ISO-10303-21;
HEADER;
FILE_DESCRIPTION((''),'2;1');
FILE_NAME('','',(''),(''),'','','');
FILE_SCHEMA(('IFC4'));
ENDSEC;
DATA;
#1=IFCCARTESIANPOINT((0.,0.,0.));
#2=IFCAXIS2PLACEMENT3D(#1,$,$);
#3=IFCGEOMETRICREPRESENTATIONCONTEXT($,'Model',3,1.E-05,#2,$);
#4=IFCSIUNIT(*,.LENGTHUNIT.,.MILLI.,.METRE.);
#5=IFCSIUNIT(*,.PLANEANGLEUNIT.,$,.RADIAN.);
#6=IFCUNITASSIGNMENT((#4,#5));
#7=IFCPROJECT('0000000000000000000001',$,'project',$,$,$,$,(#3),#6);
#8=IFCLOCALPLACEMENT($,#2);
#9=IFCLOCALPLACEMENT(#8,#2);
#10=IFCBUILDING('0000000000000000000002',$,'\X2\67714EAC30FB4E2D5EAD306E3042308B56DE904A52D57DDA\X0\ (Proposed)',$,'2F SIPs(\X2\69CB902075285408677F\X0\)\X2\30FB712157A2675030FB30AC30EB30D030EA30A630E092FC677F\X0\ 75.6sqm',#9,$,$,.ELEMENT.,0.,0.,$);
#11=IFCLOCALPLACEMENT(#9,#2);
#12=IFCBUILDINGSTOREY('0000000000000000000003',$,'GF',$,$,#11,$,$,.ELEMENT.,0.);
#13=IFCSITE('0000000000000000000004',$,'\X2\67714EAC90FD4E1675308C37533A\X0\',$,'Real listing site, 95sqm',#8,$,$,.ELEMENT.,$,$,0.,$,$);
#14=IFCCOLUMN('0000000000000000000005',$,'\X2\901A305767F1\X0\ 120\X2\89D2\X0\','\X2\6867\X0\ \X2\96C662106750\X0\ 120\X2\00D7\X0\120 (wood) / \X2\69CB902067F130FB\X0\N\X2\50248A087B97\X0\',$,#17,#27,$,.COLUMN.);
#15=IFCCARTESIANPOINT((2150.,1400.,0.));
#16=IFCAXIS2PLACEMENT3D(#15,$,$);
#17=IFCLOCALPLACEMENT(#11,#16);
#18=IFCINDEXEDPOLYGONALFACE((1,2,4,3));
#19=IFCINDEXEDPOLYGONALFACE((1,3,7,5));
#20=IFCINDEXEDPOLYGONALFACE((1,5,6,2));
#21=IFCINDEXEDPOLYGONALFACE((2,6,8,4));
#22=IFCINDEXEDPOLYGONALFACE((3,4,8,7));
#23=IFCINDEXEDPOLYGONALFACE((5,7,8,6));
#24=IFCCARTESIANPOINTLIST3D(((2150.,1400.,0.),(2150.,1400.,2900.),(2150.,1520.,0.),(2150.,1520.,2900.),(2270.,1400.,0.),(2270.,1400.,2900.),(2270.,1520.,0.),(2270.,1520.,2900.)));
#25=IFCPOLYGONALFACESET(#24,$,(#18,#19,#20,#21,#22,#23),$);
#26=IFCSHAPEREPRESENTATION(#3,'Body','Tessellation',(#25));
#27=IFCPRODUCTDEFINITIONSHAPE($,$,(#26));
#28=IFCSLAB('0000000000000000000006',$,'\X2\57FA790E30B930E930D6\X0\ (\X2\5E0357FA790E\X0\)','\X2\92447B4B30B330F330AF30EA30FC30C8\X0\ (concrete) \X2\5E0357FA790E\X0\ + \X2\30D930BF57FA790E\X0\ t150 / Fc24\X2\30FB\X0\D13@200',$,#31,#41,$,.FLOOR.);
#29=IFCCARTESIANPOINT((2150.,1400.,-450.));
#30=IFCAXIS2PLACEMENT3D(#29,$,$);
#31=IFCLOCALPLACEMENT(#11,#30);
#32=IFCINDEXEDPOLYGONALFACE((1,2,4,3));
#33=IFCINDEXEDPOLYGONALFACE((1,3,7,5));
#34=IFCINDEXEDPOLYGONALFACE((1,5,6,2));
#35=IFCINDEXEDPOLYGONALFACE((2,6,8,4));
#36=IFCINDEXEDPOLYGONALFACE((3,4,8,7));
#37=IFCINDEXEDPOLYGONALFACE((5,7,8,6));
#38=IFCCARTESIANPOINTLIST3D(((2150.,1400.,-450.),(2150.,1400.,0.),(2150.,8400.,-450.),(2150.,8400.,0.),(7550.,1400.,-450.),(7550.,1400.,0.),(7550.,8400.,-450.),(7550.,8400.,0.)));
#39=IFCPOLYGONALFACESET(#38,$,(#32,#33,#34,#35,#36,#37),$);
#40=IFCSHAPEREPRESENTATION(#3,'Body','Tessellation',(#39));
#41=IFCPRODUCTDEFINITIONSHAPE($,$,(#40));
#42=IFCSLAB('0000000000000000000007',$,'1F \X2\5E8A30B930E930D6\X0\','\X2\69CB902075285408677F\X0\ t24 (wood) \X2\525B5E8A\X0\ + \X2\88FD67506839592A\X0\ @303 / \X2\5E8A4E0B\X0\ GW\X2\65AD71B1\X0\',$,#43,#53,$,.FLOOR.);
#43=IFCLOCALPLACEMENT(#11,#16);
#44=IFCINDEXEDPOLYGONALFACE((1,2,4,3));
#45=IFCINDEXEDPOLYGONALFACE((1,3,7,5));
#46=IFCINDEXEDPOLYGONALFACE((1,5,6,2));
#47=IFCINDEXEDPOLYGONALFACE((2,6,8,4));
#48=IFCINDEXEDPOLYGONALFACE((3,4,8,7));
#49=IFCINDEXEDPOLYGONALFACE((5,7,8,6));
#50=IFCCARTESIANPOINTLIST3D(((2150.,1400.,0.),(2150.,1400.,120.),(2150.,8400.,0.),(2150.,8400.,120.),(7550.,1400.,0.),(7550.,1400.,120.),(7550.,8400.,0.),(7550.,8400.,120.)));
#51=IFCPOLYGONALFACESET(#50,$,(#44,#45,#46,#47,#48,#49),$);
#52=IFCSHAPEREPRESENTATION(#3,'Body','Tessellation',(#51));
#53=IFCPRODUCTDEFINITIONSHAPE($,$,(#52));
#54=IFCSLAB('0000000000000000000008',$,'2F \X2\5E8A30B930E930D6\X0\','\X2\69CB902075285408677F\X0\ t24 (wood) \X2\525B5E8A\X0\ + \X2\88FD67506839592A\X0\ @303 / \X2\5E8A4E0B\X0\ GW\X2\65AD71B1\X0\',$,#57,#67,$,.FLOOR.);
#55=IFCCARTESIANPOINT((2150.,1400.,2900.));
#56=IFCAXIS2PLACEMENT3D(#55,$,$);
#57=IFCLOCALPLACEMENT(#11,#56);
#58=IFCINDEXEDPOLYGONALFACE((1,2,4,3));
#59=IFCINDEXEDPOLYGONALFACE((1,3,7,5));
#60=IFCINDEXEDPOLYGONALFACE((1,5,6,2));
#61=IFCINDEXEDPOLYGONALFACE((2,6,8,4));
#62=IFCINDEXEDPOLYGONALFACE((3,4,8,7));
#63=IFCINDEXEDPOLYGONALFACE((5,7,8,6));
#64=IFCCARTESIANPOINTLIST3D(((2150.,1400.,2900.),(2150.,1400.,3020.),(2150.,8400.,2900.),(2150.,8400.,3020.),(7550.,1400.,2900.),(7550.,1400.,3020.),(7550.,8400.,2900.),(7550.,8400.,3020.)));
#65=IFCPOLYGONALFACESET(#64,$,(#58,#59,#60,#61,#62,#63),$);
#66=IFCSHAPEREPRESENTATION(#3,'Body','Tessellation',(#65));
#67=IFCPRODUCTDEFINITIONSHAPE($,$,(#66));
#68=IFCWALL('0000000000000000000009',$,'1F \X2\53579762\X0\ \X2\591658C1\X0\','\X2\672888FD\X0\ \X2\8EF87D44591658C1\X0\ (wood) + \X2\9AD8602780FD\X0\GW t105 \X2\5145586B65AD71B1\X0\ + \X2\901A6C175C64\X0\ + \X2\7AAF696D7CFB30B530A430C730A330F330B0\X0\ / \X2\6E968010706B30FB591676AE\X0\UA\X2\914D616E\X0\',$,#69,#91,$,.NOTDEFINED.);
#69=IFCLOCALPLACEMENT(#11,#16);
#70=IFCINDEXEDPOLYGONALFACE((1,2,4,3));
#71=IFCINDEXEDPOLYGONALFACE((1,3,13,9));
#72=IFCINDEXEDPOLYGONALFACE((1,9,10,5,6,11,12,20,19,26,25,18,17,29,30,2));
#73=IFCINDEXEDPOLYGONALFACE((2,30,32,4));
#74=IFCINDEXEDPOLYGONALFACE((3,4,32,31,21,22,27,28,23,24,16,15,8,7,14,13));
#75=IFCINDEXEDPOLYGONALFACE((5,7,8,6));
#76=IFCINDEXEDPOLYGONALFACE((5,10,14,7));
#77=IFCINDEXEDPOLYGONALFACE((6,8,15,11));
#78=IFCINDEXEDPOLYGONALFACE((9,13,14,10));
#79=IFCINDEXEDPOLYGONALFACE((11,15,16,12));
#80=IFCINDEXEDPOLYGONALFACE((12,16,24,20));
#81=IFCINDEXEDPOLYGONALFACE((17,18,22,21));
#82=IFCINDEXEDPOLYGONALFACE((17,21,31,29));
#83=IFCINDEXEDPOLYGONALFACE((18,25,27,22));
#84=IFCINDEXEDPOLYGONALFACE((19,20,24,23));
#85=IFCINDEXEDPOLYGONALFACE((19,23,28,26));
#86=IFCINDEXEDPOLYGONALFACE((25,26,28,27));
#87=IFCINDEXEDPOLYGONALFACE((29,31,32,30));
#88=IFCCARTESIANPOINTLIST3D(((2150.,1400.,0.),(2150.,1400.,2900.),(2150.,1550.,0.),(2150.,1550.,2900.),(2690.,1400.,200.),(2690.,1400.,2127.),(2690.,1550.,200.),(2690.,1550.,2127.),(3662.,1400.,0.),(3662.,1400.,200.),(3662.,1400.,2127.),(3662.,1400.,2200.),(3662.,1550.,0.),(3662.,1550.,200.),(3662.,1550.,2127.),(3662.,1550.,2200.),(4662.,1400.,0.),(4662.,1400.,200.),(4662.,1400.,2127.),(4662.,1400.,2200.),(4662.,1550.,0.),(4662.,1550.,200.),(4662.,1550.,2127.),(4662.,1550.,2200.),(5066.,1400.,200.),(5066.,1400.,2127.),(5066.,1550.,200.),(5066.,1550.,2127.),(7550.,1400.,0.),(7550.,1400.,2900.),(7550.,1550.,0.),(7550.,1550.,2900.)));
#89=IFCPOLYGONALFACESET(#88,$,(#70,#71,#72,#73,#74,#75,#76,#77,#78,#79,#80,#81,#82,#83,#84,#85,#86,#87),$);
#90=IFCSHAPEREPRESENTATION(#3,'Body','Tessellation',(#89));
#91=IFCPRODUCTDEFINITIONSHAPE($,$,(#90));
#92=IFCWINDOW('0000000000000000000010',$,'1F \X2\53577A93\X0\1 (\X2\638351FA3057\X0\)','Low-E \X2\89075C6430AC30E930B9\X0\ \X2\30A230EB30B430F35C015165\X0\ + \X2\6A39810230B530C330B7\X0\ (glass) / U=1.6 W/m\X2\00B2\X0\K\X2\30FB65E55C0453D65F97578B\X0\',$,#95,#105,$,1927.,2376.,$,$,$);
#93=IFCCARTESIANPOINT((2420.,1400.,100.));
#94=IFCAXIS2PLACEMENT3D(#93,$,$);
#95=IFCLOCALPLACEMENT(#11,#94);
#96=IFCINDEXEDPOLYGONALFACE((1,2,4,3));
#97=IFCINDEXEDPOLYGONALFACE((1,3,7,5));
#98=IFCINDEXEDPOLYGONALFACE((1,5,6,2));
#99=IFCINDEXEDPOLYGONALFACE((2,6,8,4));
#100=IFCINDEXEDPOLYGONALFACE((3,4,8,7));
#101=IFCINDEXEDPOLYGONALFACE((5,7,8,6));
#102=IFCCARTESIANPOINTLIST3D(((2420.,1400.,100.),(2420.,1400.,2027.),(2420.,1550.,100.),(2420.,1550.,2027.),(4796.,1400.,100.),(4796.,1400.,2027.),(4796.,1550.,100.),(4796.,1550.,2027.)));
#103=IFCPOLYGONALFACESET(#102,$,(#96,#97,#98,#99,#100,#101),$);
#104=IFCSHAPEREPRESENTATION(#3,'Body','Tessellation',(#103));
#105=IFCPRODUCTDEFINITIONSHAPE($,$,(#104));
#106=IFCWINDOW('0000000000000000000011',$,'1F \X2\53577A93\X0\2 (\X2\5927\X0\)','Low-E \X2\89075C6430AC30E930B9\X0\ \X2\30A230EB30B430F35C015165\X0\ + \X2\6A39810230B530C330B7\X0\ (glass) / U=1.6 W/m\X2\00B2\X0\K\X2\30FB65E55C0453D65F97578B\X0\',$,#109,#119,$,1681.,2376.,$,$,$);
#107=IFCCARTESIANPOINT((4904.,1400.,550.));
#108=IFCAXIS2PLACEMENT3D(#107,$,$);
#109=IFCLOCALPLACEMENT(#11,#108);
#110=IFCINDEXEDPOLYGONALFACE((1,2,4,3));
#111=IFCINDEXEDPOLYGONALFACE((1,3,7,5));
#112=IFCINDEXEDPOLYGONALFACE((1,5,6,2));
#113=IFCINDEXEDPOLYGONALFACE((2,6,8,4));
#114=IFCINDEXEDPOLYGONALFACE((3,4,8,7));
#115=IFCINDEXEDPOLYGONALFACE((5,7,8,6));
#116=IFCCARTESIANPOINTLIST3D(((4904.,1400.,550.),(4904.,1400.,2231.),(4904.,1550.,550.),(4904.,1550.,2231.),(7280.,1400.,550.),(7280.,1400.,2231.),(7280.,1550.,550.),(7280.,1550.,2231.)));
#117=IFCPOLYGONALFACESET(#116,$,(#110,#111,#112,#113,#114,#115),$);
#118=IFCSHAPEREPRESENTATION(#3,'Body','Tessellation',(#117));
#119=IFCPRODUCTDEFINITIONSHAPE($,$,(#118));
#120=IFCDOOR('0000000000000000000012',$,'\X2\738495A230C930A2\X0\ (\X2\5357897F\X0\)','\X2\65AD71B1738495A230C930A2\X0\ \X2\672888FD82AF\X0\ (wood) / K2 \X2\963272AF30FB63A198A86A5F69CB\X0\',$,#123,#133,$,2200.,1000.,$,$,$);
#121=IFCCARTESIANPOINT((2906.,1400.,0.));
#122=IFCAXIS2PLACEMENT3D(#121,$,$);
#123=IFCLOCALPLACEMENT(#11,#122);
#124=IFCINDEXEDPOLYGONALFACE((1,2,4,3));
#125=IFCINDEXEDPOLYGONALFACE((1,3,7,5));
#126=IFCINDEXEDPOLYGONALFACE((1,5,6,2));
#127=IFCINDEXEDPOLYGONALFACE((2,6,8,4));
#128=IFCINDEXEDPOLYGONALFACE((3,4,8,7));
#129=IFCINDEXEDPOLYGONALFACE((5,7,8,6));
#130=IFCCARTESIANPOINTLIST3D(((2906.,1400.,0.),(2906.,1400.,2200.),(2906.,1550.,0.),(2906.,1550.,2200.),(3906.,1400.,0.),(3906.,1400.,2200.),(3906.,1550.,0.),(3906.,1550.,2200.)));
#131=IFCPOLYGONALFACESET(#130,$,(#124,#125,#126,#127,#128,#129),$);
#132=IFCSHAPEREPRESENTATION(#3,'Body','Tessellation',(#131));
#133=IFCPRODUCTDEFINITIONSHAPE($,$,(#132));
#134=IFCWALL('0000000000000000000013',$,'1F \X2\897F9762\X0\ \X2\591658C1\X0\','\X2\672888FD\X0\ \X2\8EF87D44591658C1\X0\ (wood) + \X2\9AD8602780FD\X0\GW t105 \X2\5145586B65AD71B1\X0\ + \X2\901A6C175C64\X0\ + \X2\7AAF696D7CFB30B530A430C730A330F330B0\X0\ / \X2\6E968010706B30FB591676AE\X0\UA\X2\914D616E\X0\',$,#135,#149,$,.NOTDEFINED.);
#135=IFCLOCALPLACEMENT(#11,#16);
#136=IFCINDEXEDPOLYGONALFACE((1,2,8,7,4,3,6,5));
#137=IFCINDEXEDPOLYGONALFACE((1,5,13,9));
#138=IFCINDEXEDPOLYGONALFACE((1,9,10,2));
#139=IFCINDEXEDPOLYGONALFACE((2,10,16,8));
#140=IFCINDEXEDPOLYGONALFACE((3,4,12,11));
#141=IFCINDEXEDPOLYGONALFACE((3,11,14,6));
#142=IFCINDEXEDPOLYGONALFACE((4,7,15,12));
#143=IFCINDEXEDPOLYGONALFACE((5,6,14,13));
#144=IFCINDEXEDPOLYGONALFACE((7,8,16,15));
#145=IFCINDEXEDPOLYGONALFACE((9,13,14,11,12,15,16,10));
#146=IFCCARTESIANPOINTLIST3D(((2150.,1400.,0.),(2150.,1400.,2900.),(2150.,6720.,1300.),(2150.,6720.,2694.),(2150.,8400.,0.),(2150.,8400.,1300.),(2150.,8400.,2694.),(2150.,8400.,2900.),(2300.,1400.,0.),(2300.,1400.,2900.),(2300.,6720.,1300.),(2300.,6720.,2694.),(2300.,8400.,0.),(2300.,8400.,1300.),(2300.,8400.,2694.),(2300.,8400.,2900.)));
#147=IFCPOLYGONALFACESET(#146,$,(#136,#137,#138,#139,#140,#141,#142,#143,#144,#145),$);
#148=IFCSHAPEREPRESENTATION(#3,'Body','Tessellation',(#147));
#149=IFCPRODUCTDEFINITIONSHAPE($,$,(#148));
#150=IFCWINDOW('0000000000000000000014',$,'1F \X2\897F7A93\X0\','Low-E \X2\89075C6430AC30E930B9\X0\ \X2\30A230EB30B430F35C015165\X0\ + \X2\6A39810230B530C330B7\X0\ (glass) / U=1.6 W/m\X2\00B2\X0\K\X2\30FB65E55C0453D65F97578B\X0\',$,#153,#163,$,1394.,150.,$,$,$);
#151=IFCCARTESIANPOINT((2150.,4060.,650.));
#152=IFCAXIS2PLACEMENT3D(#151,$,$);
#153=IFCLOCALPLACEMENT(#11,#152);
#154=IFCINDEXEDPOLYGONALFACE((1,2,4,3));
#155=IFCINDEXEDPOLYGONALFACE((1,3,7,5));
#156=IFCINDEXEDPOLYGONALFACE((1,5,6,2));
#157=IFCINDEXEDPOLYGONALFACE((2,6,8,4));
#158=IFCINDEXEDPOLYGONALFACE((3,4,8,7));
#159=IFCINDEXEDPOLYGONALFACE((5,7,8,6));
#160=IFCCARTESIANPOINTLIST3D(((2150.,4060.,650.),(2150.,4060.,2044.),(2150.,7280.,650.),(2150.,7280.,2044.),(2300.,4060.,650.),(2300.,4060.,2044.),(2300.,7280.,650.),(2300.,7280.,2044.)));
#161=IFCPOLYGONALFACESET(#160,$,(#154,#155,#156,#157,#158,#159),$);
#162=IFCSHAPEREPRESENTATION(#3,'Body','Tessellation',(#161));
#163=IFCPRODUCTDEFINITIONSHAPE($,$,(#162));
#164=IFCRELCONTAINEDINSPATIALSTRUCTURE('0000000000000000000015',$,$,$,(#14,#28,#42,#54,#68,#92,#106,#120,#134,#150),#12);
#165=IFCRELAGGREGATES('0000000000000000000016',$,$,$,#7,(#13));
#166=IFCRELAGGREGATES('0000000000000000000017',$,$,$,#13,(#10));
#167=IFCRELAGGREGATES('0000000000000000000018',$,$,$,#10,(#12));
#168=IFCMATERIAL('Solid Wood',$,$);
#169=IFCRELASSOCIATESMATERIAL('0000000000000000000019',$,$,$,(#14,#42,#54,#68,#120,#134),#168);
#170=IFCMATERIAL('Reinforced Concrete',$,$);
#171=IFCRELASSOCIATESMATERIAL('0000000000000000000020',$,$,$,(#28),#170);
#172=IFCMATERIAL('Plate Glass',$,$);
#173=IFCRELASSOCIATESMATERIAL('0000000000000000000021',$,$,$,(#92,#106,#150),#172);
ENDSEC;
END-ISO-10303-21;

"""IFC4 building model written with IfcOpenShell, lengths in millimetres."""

from ifc_helpers import new_model, si_unit, frame, frame_2d, origin, place, context, project, spatial, rectangle, extrude, material, element, fill, save


model = new_model("IFC4")

# Units and contexts
model_context = context("Model", 3, precision=1e-05, world=origin())
ifc_project = project(units=[si_unit("LENGTHUNIT", "METRE", prefix="MILLI"), si_unit("PLANEANGLEUNIT", "RADIAN")], contexts=[model_context])

# Site, building, storey
site_placement = place(None, origin())
site = spatial("IfcSite", under=ifc_project, at=site_placement, Name="東京都世田谷区", ObjectType="Real listing site, 95sqm", CompositionType="ELEMENT", RefElevation=0.0)
building_placement = place(site_placement, origin())
building = spatial("IfcBuilding", under=site, at=building_placement, Name="東京・中庭のある回遊動線 (Proposed)", ObjectType="2F SIPs(構造用合板)・無垢材・ガルバリウム鋼板 75.6sqm", CompositionType="ELEMENT", ElevationOfRefHeight=0.0, ElevationOfTerrain=0.0)
storey_placement = place(building_placement, origin())
storey = spatial("IfcBuildingStorey", under=building, at=storey_placement, Name="GF", CompositionType="ELEMENT", Elevation=0.0)

# Column
ifc_material_1 = material(Name="Solid Wood")
column_placement = place(storey_placement, frame((2150.0, 1400.0, 0.0)))
element("IfcColumn", 1, at=column_placement, inside=storey, material=ifc_material_1, Name="通し柱 120角", Description="桧 集成材 120×120 (wood) / 構造柱・N値計算", PredefinedType="COLUMN", context=model_context, shape_type="SweptSolid", body=[
    extrude(rectangle(XDim=120.0, YDim=120.0, at=frame_2d((60.0, 60.0))), frame((2150.0, 1400.0, 0.0)), (0.0, 0.0, 1.0), 2900.0),
])

# Slabs
ifc_material_2 = material(Name="Reinforced Concrete")
slab_1_placement = place(storey_placement, frame((2150.0, 1400.0, -450.0)))
element("IfcSlab", 2, at=slab_1_placement, inside=storey, material=ifc_material_2, Name="基礎スラブ (布基礎)", Description="鉄筋コンクリート (concrete) 布基礎 + ベタ基礎 t150 / Fc24・D13@200", PredefinedType="FLOOR", context=model_context, shape_type="SweptSolid", body=[
    extrude(rectangle(XDim=5400.0, YDim=7000.0, at=frame_2d((2700.0, 3500.0))), frame((2150.0, 1400.0, -450.0)), (0.0, 0.0, 1.0), 450.0),
])
slab_2_placement = place(storey_placement, frame((2150.0, 1400.0, 0.0)))
element("IfcSlab", 3, at=slab_2_placement, inside=storey, material=ifc_material_1, Name="1F 床スラブ", Description="構造用合板 t24 (wood) 剛床 + 製材根太 @303 / 床下 GW断熱", PredefinedType="FLOOR", context=model_context, shape_type="SweptSolid", body=[
    extrude(rectangle(XDim=5400.0, YDim=7000.0, at=frame_2d((2700.0, 3500.0))), frame((2150.0, 1400.0, 0.0)), (0.0, 0.0, 1.0), 120.0),
])
slab_3_placement = place(storey_placement, frame((2150.0, 1400.0, 2900.0)))
element("IfcSlab", 4, at=slab_3_placement, inside=storey, material=ifc_material_1, Name="2F 床スラブ", Description="構造用合板 t24 (wood) 剛床 + 製材根太 @303 / 床下 GW断熱", PredefinedType="FLOOR", context=model_context, shape_type="SweptSolid", body=[
    extrude(rectangle(XDim=5400.0, YDim=7000.0, at=frame_2d((2700.0, 3500.0))), frame((2150.0, 1400.0, 2900.0)), (0.0, 0.0, 1.0), 120.0),
])

# Wall, openings, windows, door
wall_1_placement = place(storey_placement, frame((2150.0, 1400.0, 0.0)))
wall_1 = element("IfcWall", 5, at=wall_1_placement, inside=storey, material=ifc_material_1, Name="1F 南面 外壁", Description="木製 軸組外壁 (wood) + 高性能GW t105 充填断熱 + 通気層 + 窯業系サイディング / 準耐火・外皮UA配慮", PredefinedType="NOTDEFINED", context=model_context, shape_type="SweptSolid", body=[
    extrude(rectangle(XDim=5400.0, YDim=150.0, at=frame_2d((2700.0, 75.0))), frame((2150.0, 1400.0, 0.0)), (0.0, 0.0, 1.0), 2900.0),
])
opening_1_placement = place(storey_placement, frame((2420.0, 1400.0, 100.0)))
opening_1 = element("IfcOpeningElement", 6, at=opening_1_placement, cuts=wall_1, PredefinedType="NOTDEFINED", context=model_context, shape_type="SweptSolid", body=[
    extrude(rectangle(XDim=2376.0, YDim=150.0, at=frame_2d((1188.0, 75.0))), frame((2420.0, 1400.0, 100.0)), (0.0, 0.0, 1.0), 1927.0),
])
opening_2_placement = place(storey_placement, frame((4904.0, 1400.0, 550.0)))
opening_2 = element("IfcOpeningElement", 7, at=opening_2_placement, cuts=wall_1, PredefinedType="NOTDEFINED", context=model_context, shape_type="SweptSolid", body=[
    extrude(rectangle(XDim=2376.0, YDim=150.0, at=frame_2d((1188.0, 75.0))), frame((4904.0, 1400.0, 550.0)), (0.0, 0.0, 1.0), 1681.0),
])
opening_3_placement = place(storey_placement, frame((2906.0, 1400.0, 0.0)))
opening_3 = element("IfcOpeningElement", 8, at=opening_3_placement, cuts=wall_1, PredefinedType="NOTDEFINED", context=model_context, shape_type="SweptSolid", body=[
    extrude(rectangle(XDim=1000.0, YDim=150.0, at=frame_2d((500.0, 75.0))), frame((2906.0, 1400.0, 0.0)), (0.0, 0.0, 1.0), 2200.0),
])
ifc_material_3 = material(Name="Plate Glass")
window_1_placement = place(storey_placement, frame((2420.0, 1400.0, 100.0)))
window_1 = element("IfcWindow", 9, at=window_1_placement, inside=storey, material=ifc_material_3, Name="1F 南窓1 (掃出し)", Description="Low-E 複層ガラス アルゴン封入 + 樹脂サッシ (glass) / U=1.6 W/m²K・日射取得型", OverallHeight=1927.0, OverallWidth=2376.0, context=model_context, shape_type="SweptSolid", body=[
    extrude(rectangle(XDim=2376.0, YDim=150.0, at=frame_2d((1188.0, 75.0))), frame((2420.0, 1400.0, 100.0)), (0.0, 0.0, 1.0), 1927.0),
])
fill(opening_1, window_1)
window_2_placement = place(storey_placement, frame((4904.0, 1400.0, 550.0)))
window_2 = element("IfcWindow", 10, at=window_2_placement, inside=storey, material=ifc_material_3, Name="1F 南窓2 (大)", Description="Low-E 複層ガラス アルゴン封入 + 樹脂サッシ (glass) / U=1.6 W/m²K・日射取得型", OverallHeight=1681.0, OverallWidth=2376.0, context=model_context, shape_type="SweptSolid", body=[
    extrude(rectangle(XDim=2376.0, YDim=150.0, at=frame_2d((1188.0, 75.0))), frame((4904.0, 1400.0, 550.0)), (0.0, 0.0, 1.0), 1681.0),
])
fill(opening_2, window_2)
door_placement = place(storey_placement, frame((2906.0, 1400.0, 0.0)))
door = element("IfcDoor", 11, at=door_placement, inside=storey, material=ifc_material_1, Name="玄関ドア (南西)", Description="断熱玄関ドア 木製芯 (wood) / K2 防犯・採風機構", OverallHeight=2200.0, OverallWidth=1000.0, context=model_context, shape_type="SweptSolid", body=[
    extrude(rectangle(XDim=1000.0, YDim=150.0, at=frame_2d((500.0, 75.0))), frame((2906.0, 1400.0, 0.0)), (0.0, 0.0, 1.0), 2200.0),
])
fill(opening_3, door)

# Wall, opening, window
wall_2_placement = place(storey_placement, frame((2150.0, 1400.0, 0.0)))
wall_2 = element("IfcWall", 12, at=wall_2_placement, inside=storey, material=ifc_material_1, Name="1F 西面 外壁", Description="木製 軸組外壁 (wood) + 高性能GW t105 充填断熱 + 通気層 + 窯業系サイディング / 準耐火・外皮UA配慮", PredefinedType="NOTDEFINED", context=model_context, shape_type="SweptSolid", body=[
    extrude(rectangle(XDim=150.0, YDim=7000.0, at=frame_2d((75.0, 3500.0))), frame((2150.0, 1400.0, 0.0)), (0.0, 0.0, 1.0), 2900.0),
])
opening_4_placement = place(storey_placement, frame((2150.0, 4060.0, 650.0)))
opening_4 = element("IfcOpeningElement", 13, at=opening_4_placement, cuts=wall_2, PredefinedType="NOTDEFINED", context=model_context, shape_type="SweptSolid", body=[
    extrude(rectangle(XDim=150.0, YDim=3220.0, at=frame_2d((75.0, 1610.0))), frame((2150.0, 4060.0, 650.0)), (0.0, 0.0, 1.0), 1394.0),
])
window_3_placement = place(storey_placement, frame((2150.0, 4060.0, 650.0)))
window_3 = element("IfcWindow", 14, at=window_3_placement, inside=storey, material=ifc_material_3, Name="1F 西窓", Description="Low-E 複層ガラス アルゴン封入 + 樹脂サッシ (glass) / U=1.6 W/m²K・日射取得型", OverallHeight=1394.0, OverallWidth=150.0, context=model_context, shape_type="SweptSolid", body=[
    extrude(rectangle(XDim=150.0, YDim=3220.0, at=frame_2d((75.0, 1610.0))), frame((2150.0, 4060.0, 650.0)), (0.0, 0.0, 1.0), 1394.0),
])
fill(opening_4, window_3)

save(model, "model.ifc")
